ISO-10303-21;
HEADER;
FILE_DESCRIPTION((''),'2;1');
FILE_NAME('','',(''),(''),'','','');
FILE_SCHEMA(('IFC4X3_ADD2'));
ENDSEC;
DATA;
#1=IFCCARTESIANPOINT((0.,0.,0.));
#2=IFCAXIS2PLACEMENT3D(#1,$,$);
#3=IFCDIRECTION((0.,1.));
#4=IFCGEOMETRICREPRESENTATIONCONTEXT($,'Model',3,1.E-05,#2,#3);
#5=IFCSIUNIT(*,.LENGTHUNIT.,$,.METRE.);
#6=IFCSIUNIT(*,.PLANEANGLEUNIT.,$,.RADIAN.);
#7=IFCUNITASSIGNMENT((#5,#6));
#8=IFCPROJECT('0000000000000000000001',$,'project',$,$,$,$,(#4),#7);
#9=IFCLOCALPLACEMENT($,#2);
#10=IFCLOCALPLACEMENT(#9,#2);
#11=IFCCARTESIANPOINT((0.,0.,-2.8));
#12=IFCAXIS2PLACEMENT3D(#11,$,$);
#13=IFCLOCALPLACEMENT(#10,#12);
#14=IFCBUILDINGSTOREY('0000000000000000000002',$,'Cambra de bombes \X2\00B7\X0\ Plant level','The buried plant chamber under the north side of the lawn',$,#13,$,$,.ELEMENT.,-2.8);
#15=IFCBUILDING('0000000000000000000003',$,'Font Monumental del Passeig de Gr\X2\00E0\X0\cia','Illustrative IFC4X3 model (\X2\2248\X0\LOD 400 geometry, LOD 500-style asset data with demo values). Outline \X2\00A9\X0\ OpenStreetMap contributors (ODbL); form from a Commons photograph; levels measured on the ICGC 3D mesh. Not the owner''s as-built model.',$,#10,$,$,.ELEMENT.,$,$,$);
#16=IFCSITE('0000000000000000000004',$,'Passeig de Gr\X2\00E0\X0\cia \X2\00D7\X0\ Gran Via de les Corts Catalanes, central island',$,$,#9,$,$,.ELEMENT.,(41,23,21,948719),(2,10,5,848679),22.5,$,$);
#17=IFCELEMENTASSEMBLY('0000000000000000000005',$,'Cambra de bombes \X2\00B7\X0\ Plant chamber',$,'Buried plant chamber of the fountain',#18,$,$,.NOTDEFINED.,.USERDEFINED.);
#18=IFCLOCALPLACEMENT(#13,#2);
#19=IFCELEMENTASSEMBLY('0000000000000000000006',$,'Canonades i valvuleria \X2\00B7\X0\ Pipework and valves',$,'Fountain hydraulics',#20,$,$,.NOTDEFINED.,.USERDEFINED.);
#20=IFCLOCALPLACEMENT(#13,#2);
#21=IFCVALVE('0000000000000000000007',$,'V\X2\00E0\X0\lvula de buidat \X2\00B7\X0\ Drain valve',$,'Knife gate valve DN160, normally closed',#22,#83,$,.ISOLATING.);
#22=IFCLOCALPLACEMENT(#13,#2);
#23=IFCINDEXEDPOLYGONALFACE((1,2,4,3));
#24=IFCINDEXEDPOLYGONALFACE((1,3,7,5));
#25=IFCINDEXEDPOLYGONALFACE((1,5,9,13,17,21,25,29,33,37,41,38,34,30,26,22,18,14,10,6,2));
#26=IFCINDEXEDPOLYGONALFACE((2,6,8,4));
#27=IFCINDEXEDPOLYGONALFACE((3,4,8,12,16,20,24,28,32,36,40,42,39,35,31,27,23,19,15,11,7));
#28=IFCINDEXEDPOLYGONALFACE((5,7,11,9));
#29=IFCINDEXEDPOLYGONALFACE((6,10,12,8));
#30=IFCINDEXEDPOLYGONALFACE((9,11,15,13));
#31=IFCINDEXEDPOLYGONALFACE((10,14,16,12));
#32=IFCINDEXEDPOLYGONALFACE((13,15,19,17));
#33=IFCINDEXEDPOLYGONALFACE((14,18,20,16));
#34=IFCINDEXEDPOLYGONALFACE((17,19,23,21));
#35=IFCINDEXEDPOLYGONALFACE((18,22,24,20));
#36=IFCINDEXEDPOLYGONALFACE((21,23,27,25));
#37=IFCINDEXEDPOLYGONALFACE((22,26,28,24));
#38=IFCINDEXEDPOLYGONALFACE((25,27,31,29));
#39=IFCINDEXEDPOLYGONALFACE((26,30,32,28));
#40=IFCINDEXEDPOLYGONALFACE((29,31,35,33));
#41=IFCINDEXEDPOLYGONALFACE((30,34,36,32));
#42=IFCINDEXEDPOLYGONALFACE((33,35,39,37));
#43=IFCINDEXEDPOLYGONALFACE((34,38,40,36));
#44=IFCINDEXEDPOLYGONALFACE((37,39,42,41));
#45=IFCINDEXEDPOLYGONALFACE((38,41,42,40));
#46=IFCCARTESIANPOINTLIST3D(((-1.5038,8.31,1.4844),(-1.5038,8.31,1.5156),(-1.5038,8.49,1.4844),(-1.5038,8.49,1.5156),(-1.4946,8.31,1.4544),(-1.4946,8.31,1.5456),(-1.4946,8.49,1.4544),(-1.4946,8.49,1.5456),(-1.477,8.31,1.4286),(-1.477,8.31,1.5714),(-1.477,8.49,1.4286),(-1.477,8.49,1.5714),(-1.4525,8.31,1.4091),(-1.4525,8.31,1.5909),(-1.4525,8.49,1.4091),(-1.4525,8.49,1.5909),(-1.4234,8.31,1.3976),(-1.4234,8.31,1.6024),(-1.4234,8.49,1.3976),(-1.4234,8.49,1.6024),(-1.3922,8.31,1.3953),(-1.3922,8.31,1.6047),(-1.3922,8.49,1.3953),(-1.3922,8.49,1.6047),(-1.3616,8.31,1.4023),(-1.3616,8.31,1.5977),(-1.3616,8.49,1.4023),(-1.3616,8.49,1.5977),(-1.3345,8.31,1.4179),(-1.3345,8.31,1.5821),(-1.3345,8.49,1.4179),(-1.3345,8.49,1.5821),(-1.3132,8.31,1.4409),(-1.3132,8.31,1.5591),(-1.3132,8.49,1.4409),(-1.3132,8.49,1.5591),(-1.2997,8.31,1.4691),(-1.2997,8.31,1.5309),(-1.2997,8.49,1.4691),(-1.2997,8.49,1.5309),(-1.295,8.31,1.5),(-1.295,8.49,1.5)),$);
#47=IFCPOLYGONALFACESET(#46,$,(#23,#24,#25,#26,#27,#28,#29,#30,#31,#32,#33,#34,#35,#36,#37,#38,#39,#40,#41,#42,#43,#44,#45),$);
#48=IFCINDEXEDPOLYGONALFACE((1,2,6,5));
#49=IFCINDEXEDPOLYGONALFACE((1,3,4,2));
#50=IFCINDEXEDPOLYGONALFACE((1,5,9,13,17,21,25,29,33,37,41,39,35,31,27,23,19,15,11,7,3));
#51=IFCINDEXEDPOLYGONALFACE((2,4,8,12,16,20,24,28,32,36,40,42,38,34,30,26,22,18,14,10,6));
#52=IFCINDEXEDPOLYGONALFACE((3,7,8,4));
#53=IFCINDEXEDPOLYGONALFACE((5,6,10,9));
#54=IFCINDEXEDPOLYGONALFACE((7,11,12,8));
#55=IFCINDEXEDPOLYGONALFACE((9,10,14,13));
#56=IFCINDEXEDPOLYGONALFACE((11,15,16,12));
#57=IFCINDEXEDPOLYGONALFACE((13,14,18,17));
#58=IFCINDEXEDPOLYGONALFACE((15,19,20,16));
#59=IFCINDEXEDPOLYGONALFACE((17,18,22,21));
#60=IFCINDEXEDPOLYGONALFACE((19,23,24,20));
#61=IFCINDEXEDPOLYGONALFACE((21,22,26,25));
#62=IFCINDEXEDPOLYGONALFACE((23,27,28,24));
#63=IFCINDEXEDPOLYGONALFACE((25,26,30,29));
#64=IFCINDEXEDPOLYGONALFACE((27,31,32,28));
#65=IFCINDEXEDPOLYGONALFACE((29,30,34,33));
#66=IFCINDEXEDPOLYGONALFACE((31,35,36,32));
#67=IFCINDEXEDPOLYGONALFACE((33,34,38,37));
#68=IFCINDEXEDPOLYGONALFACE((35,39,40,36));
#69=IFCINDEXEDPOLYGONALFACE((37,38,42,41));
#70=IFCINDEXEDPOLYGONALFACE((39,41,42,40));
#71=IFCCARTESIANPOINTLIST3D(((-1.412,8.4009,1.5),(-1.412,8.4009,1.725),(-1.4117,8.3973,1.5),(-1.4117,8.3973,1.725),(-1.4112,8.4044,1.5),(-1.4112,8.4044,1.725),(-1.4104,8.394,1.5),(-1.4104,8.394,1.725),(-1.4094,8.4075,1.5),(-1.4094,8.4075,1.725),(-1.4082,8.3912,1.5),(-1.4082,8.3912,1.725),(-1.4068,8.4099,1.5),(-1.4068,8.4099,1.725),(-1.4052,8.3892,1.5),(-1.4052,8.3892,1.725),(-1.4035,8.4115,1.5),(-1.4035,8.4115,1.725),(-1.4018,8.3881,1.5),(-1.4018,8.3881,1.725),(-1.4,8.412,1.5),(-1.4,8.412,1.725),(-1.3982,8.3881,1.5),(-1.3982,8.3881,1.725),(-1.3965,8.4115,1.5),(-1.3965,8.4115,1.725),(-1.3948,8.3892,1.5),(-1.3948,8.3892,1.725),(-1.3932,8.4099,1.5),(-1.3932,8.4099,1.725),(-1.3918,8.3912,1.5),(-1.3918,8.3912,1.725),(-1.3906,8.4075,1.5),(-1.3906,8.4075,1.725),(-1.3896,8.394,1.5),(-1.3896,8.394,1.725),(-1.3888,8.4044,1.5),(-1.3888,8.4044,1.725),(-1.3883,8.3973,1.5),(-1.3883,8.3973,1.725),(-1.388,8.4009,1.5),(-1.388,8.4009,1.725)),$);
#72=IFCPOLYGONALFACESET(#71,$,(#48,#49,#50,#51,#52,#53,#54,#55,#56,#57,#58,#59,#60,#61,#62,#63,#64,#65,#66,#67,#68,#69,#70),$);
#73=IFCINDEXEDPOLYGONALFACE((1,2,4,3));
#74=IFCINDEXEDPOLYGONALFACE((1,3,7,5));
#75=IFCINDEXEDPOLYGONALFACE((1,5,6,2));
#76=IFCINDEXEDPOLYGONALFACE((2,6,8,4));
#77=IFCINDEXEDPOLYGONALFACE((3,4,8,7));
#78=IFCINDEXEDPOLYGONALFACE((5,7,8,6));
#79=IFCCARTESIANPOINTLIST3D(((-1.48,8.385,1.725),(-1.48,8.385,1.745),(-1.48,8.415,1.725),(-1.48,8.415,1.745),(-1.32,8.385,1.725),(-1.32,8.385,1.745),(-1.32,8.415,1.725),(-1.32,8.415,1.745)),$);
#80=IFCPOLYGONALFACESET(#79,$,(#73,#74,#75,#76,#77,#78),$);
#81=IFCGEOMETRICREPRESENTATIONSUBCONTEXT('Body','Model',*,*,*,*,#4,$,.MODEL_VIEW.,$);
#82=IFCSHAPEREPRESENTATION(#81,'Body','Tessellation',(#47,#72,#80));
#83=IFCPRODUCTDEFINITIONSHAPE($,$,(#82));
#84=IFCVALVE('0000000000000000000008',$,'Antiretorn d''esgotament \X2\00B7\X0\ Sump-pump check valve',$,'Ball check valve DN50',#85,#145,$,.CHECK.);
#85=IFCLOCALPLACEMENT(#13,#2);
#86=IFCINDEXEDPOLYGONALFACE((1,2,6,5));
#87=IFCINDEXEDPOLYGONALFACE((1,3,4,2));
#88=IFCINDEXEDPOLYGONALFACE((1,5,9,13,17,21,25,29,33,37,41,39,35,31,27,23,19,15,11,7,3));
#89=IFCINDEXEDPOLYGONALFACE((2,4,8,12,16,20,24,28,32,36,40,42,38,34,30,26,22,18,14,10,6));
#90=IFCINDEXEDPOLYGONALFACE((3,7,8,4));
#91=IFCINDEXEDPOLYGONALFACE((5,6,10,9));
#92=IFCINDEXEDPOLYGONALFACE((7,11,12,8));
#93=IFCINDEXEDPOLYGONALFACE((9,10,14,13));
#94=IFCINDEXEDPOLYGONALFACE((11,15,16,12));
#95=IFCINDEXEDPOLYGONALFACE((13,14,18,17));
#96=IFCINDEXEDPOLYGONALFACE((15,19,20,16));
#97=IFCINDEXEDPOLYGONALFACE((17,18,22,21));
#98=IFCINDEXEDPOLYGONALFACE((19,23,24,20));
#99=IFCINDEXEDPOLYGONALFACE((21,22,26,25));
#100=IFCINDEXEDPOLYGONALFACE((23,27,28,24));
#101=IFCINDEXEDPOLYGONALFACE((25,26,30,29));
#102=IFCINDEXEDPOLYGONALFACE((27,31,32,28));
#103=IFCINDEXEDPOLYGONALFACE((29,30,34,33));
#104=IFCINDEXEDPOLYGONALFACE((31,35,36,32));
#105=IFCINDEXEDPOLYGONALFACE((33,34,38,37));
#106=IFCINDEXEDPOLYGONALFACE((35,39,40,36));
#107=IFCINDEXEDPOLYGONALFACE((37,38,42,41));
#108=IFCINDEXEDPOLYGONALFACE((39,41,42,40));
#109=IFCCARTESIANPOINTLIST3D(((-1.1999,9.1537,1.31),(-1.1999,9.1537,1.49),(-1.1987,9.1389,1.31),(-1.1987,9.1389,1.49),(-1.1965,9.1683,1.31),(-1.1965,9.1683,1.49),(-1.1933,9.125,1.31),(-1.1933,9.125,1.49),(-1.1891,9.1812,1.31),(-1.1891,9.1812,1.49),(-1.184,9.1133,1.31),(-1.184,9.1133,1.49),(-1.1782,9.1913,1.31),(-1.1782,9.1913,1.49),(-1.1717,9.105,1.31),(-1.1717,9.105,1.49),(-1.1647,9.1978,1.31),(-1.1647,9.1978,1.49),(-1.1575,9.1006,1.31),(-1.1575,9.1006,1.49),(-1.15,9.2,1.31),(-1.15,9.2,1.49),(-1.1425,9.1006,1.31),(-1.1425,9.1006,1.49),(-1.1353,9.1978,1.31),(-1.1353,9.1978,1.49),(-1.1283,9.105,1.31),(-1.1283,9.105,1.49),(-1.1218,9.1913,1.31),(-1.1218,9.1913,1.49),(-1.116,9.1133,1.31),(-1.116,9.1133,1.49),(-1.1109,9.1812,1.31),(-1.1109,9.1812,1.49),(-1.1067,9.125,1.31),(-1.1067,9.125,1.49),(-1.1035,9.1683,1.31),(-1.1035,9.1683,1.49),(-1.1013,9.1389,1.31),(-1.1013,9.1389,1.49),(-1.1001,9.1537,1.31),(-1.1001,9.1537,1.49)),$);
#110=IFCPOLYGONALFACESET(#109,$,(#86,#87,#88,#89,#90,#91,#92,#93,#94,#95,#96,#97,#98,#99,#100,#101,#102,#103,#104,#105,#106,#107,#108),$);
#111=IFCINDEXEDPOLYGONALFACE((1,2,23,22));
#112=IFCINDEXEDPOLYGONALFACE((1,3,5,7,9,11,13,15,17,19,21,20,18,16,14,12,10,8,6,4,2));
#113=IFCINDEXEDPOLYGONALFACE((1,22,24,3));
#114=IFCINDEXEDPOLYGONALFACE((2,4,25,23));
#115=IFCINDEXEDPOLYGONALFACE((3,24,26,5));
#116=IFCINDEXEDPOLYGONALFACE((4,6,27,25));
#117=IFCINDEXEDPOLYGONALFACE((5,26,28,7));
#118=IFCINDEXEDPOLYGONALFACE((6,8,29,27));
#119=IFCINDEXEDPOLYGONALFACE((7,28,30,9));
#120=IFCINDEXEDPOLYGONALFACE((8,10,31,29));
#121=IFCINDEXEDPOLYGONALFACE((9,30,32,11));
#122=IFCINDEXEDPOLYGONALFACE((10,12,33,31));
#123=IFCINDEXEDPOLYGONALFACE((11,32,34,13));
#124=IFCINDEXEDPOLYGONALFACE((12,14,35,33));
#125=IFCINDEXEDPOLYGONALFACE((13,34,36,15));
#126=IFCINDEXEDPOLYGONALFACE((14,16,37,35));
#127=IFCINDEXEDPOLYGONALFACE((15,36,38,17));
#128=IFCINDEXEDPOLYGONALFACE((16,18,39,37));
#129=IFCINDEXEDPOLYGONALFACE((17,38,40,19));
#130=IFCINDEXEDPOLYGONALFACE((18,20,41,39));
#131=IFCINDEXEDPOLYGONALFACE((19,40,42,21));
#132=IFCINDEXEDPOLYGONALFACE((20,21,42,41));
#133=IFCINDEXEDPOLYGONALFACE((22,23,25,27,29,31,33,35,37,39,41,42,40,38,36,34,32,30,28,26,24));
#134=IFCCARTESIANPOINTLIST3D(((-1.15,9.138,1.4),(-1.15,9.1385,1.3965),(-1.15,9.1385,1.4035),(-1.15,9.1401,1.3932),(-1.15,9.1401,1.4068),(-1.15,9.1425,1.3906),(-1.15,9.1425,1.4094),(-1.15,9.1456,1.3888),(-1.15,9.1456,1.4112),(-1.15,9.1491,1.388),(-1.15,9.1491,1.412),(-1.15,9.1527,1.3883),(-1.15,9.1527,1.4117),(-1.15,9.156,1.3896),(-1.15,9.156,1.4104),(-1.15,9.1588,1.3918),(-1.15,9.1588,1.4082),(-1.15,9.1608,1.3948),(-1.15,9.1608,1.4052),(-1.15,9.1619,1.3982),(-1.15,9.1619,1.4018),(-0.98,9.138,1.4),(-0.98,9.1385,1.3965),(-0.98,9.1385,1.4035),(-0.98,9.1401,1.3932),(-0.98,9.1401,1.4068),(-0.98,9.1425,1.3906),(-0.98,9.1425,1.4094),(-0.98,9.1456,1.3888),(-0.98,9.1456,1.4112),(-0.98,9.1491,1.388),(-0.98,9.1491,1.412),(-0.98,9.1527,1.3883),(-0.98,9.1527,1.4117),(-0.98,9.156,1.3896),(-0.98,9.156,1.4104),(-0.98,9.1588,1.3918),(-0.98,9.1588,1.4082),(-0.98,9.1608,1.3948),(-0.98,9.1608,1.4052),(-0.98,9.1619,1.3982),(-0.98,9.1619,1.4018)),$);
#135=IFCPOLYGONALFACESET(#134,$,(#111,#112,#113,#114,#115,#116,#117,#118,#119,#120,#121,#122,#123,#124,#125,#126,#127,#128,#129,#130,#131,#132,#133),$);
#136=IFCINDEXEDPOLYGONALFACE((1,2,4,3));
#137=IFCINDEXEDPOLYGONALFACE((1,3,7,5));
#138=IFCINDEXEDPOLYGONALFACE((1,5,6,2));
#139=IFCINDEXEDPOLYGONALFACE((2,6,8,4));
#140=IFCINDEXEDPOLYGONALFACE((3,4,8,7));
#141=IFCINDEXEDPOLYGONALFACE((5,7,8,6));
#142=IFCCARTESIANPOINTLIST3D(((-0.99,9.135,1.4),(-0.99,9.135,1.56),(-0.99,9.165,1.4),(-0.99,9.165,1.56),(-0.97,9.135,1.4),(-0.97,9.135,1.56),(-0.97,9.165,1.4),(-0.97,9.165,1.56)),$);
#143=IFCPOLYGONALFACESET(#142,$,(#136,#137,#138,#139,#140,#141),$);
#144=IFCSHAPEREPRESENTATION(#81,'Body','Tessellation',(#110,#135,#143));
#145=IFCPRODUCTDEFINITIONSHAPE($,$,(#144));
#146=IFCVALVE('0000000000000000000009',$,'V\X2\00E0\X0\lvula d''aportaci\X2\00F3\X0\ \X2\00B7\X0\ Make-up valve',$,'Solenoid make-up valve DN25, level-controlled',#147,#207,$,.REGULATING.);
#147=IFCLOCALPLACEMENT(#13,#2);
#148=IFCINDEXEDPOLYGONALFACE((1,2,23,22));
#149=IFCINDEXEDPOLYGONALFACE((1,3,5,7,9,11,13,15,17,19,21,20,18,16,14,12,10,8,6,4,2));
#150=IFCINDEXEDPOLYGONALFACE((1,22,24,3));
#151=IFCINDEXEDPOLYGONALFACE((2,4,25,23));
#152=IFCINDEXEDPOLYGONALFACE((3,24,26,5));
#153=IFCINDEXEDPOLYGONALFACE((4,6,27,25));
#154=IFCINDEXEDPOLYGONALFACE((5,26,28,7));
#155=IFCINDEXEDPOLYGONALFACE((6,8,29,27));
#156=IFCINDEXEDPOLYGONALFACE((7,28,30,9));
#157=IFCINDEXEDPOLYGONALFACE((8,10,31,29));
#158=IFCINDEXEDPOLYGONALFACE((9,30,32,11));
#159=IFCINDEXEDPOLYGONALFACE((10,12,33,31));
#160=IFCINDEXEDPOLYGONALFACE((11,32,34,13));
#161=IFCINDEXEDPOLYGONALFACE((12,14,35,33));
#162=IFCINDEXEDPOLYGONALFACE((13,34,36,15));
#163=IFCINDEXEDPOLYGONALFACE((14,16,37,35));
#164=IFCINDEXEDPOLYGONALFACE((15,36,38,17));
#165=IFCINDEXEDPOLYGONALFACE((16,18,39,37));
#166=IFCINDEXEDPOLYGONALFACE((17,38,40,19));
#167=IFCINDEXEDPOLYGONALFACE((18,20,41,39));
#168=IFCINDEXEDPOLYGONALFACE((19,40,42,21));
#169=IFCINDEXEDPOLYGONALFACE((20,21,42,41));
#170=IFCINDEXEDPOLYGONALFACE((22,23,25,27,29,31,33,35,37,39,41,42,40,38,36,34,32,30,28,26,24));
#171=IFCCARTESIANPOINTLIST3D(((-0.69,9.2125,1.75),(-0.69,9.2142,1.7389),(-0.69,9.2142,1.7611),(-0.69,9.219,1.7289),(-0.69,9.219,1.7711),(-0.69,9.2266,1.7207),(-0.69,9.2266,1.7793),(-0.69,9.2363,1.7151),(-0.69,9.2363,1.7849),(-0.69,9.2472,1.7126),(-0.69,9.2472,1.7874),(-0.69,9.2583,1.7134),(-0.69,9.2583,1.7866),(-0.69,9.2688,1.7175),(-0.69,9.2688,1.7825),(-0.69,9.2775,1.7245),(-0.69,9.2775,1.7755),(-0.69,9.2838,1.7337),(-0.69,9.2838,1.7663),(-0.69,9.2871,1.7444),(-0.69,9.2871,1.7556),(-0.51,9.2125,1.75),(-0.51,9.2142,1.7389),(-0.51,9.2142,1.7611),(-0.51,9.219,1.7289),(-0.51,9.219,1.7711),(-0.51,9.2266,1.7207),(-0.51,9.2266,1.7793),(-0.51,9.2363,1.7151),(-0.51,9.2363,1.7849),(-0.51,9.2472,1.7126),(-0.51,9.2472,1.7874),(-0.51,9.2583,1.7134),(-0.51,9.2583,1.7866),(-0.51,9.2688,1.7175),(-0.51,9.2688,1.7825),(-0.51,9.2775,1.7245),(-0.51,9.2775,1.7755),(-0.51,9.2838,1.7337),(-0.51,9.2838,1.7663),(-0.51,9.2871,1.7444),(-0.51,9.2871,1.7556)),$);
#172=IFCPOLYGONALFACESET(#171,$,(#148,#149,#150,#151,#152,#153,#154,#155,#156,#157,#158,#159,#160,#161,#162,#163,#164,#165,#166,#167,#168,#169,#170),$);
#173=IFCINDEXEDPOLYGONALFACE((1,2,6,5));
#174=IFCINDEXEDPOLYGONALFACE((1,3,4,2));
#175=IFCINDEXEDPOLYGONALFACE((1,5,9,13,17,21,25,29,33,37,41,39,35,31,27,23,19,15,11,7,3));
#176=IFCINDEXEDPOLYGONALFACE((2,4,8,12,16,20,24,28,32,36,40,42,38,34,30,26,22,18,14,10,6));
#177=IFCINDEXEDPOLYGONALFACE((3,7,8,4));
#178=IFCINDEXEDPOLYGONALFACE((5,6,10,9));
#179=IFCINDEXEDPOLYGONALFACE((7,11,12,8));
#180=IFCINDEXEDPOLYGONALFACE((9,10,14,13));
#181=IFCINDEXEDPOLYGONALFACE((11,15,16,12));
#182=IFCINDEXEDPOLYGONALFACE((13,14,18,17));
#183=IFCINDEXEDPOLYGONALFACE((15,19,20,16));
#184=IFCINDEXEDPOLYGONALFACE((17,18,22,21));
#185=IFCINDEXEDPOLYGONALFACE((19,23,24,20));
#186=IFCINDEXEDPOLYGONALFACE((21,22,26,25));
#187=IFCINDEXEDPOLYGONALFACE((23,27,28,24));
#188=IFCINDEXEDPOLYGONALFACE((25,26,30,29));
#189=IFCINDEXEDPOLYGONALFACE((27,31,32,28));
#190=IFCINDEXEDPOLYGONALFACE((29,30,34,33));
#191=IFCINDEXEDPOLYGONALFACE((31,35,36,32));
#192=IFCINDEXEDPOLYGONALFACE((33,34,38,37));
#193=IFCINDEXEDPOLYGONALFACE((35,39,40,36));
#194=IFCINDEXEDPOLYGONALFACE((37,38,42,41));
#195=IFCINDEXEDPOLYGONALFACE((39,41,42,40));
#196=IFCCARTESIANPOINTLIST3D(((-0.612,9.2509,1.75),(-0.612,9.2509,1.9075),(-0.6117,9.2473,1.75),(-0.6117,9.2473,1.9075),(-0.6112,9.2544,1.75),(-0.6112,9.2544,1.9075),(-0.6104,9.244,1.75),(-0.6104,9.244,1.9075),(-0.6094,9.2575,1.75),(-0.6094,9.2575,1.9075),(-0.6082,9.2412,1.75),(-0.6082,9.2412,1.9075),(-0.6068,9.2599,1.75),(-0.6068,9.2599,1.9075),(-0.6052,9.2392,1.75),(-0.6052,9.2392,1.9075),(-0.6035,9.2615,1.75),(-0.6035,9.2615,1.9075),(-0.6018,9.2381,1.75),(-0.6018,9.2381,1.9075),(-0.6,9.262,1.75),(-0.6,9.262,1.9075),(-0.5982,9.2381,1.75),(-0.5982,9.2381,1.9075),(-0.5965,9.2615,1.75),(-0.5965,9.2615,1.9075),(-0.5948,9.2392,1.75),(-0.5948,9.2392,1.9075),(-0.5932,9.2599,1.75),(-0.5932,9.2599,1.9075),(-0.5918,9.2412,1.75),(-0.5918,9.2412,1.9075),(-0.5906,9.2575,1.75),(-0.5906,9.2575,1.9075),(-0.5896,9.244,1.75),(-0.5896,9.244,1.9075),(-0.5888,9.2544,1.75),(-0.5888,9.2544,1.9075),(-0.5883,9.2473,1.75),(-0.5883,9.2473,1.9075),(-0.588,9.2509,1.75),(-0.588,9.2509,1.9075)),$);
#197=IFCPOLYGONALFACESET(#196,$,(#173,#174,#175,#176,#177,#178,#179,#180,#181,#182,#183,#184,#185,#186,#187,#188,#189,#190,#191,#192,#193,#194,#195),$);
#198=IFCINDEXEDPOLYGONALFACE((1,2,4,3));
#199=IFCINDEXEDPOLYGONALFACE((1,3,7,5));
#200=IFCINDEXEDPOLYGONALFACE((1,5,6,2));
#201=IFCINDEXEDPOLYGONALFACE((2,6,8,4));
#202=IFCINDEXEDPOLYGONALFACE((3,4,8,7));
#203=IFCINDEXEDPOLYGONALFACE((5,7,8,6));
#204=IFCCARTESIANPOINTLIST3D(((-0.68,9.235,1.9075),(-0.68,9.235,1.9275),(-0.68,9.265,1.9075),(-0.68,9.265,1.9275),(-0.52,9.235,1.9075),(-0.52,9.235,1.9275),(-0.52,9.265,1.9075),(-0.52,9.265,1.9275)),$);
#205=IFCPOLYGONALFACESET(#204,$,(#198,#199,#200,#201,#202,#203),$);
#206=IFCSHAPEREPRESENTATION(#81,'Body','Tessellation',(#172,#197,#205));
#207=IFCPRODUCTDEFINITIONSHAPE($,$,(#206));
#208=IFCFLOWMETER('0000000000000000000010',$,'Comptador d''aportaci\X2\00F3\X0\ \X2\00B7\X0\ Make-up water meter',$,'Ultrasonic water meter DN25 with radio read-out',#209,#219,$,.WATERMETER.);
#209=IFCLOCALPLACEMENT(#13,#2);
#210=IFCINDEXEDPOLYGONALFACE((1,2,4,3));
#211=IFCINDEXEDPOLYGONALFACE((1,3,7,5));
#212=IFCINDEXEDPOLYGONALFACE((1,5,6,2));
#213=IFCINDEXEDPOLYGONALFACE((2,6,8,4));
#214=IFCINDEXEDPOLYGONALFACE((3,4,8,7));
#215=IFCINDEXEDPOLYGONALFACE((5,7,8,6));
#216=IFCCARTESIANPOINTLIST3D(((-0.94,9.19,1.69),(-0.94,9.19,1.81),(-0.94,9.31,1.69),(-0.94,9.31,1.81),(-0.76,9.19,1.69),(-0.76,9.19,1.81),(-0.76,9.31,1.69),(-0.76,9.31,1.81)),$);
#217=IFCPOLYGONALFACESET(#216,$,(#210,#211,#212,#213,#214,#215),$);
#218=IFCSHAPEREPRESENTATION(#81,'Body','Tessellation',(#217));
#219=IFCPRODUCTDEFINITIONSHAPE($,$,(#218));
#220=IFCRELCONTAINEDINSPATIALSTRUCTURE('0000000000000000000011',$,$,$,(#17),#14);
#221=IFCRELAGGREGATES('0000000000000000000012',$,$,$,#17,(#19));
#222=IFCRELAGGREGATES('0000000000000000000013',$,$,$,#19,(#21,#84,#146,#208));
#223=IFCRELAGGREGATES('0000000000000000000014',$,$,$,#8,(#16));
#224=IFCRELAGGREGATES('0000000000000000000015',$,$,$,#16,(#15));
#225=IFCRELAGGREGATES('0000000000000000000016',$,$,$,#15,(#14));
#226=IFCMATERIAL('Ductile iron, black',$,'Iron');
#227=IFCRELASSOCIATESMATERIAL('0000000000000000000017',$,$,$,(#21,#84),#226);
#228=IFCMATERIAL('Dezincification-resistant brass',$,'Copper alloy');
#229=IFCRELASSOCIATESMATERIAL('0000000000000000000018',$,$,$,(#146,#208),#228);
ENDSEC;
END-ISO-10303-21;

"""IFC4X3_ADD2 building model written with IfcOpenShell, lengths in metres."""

from ifc_helpers import new_model, si_unit, direction, frame, origin, origin_2d_with_axis, place, context, subcontext, project, spatial, rectangle, circle, extrude, material, element, aggregate, save


model = new_model("IFC4X3_ADD2")

# Units and contexts
model_context = context("Model", 3, precision=1e-05, world=origin(), true_north=direction((0.0, 1.0)))
body_context = subcontext(model_context, "Body", "Model", "MODEL_VIEW")
ifc_project = project(units=[si_unit("LENGTHUNIT", "METRE"), si_unit("PLANEANGLEUNIT", "RADIAN")], contexts=[model_context])

# Site, building, storey
site_placement = place(None, origin())
site = spatial("IfcSite", under=ifc_project, at=site_placement, Name="Passeig de Gràcia × Gran Via de les Corts Catalanes, central island", CompositionType="ELEMENT", RefLatitude=(41, 23, 21, 948719), RefLongitude=(2, 10, 5, 848679), RefElevation=22.5)
building_placement = place(site_placement, origin())
building = spatial("IfcBuilding", under=site, at=building_placement, Name="Font Monumental del Passeig de Gràcia", Description="Illustrative IFC4X3 model (≈LOD 400 geometry, LOD 500-style asset data with demo values). Outline © OpenStreetMap contributors (ODbL); form from a Commons photograph; levels measured on the ICGC 3D mesh. Not the owner's as-built model.", CompositionType="ELEMENT")
storey_placement = place(building_placement, frame((0.0, 0.0, -2.8)))
storey = spatial("IfcBuildingStorey", under=building, at=storey_placement, Name="Cambra de bombes · Plant level", Description="The buried plant chamber under the north side of the lawn", CompositionType="ELEMENT", Elevation=-2.8)

# Element assemblies, valves, flow meter
assembly_1_placement = place(building_placement, origin())
assembly_1 = element("IfcElementAssembly", 1, at=assembly_1_placement, inside=storey, Name="Cambra de bombes · Plant chamber", ObjectType="Buried plant chamber of the fountain", AssemblyPlace="NOTDEFINED", PredefinedType="USERDEFINED")
ifc_material_1 = material(Name="Ductile iron, black", Category="Iron")
assembly_2_placement = place(building_placement, origin())
assembly_2 = element("IfcElementAssembly", 2, at=assembly_2_placement, Name="Canonades i valvuleria · Pipework and valves", ObjectType="Fountain hydraulics", AssemblyPlace="NOTDEFINED", PredefinedType="USERDEFINED")
aggregate(assembly_1, [assembly_2])
valve_1_placement = place(building_placement, origin())
valve_1 = element("IfcValve", 3, at=valve_1_placement, material=ifc_material_1, Name="Vàlvula de buidat · Drain valve", ObjectType="Knife gate valve DN160, normally closed", PredefinedType="ISOLATING", context=body_context, shape_type="SweptSolid", body=[
    extrude(circle(Radius=0.105, at=origin_2d_with_axis()), frame((-1.4, 8.31, -1.3), z_axis=(0.0, 1.0, 0.0), x_axis=(1.0, 0.0, 0.0)), (0.0, 0.0, 1.0), 0.18),
    extrude(circle(Radius=0.012, at=origin_2d_with_axis()), frame((-1.4, 8.4, -1.3), z_axis=(0.0, 0.0, 1.0), x_axis=(0.0, 1.0, 0.0)), (0.0, 0.0, 1.0), 0.225),
    extrude(rectangle(XDim=0.16, YDim=0.03, at=origin_2d_with_axis()), frame((-1.4, 8.4, -1.075)), (0.0, 0.0, 1.0), 0.02),
])
valve_2_placement = place(building_placement, origin())
valve_2 = element("IfcValve", 4, at=valve_2_placement, material=ifc_material_1, Name="Antiretorn d'esgotament · Sump-pump check valve", ObjectType="Ball check valve DN50", PredefinedType="CHECK", context=body_context, shape_type="SweptSolid", body=[
    extrude(circle(Radius=0.05, at=origin_2d_with_axis()), frame((-1.15, 9.15, -1.49), z_axis=(0.0, 0.0, 1.0), x_axis=(0.0, 1.0, 0.0)), (0.0, 0.0, 1.0), 0.18),
    extrude(circle(Radius=0.012, at=origin_2d_with_axis()), frame((-1.15, 9.15, -1.4), z_axis=(1.0, 0.0, 0.0), x_axis=(0.0, -1.0, 0.0)), (0.0, 0.0, 1.0), 0.17),
    extrude(rectangle(XDim=0.02, YDim=0.03, at=origin_2d_with_axis()), frame((-0.98, 9.15, -1.4)), (0.0, 0.0, 1.0), 0.16),
])
ifc_material_2 = material(Name="Dezincification-resistant brass", Category="Copper alloy")
valve_3_placement = place(building_placement, origin())
valve_3 = element("IfcValve", 5, at=valve_3_placement, material=ifc_material_2, Name="Vàlvula d'aportació · Make-up valve", ObjectType="Solenoid make-up valve DN25, level-controlled", PredefinedType="REGULATING", context=body_context, shape_type="SweptSolid", body=[
    extrude(circle(Radius=0.0375, at=origin_2d_with_axis()), frame((-0.69, 9.25, -1.05), z_axis=(1.0, 0.0, 0.0), x_axis=(0.0, -1.0, 0.0)), (0.0, 0.0, 1.0), 0.18),
    extrude(circle(Radius=0.012, at=origin_2d_with_axis()), frame((-0.6, 9.25, -1.05), z_axis=(0.0, 0.0, 1.0), x_axis=(0.0, 1.0, 0.0)), (0.0, 0.0, 1.0), 0.1575),
    extrude(rectangle(XDim=0.16, YDim=0.03, at=origin_2d_with_axis()), frame((-0.6, 9.25, -0.8925)), (0.0, 0.0, 1.0), 0.02),
])
flow_meter_placement = place(building_placement, origin())
flow_meter = element("IfcFlowMeter", 6, at=flow_meter_placement, material=ifc_material_2, Name="Comptador d'aportació · Make-up water meter", ObjectType="Ultrasonic water meter DN25 with radio read-out", PredefinedType="WATERMETER", context=body_context, shape_type="SweptSolid", body=[
    extrude(rectangle(XDim=0.18, YDim=0.12, at=origin_2d_with_axis()), frame((-0.85, 9.25, -1.11)), (0.0, 0.0, 1.0), 0.12),
])
aggregate(assembly_2, [valve_1, valve_2, valve_3, flow_meter])

save(model, "model.ifc")
